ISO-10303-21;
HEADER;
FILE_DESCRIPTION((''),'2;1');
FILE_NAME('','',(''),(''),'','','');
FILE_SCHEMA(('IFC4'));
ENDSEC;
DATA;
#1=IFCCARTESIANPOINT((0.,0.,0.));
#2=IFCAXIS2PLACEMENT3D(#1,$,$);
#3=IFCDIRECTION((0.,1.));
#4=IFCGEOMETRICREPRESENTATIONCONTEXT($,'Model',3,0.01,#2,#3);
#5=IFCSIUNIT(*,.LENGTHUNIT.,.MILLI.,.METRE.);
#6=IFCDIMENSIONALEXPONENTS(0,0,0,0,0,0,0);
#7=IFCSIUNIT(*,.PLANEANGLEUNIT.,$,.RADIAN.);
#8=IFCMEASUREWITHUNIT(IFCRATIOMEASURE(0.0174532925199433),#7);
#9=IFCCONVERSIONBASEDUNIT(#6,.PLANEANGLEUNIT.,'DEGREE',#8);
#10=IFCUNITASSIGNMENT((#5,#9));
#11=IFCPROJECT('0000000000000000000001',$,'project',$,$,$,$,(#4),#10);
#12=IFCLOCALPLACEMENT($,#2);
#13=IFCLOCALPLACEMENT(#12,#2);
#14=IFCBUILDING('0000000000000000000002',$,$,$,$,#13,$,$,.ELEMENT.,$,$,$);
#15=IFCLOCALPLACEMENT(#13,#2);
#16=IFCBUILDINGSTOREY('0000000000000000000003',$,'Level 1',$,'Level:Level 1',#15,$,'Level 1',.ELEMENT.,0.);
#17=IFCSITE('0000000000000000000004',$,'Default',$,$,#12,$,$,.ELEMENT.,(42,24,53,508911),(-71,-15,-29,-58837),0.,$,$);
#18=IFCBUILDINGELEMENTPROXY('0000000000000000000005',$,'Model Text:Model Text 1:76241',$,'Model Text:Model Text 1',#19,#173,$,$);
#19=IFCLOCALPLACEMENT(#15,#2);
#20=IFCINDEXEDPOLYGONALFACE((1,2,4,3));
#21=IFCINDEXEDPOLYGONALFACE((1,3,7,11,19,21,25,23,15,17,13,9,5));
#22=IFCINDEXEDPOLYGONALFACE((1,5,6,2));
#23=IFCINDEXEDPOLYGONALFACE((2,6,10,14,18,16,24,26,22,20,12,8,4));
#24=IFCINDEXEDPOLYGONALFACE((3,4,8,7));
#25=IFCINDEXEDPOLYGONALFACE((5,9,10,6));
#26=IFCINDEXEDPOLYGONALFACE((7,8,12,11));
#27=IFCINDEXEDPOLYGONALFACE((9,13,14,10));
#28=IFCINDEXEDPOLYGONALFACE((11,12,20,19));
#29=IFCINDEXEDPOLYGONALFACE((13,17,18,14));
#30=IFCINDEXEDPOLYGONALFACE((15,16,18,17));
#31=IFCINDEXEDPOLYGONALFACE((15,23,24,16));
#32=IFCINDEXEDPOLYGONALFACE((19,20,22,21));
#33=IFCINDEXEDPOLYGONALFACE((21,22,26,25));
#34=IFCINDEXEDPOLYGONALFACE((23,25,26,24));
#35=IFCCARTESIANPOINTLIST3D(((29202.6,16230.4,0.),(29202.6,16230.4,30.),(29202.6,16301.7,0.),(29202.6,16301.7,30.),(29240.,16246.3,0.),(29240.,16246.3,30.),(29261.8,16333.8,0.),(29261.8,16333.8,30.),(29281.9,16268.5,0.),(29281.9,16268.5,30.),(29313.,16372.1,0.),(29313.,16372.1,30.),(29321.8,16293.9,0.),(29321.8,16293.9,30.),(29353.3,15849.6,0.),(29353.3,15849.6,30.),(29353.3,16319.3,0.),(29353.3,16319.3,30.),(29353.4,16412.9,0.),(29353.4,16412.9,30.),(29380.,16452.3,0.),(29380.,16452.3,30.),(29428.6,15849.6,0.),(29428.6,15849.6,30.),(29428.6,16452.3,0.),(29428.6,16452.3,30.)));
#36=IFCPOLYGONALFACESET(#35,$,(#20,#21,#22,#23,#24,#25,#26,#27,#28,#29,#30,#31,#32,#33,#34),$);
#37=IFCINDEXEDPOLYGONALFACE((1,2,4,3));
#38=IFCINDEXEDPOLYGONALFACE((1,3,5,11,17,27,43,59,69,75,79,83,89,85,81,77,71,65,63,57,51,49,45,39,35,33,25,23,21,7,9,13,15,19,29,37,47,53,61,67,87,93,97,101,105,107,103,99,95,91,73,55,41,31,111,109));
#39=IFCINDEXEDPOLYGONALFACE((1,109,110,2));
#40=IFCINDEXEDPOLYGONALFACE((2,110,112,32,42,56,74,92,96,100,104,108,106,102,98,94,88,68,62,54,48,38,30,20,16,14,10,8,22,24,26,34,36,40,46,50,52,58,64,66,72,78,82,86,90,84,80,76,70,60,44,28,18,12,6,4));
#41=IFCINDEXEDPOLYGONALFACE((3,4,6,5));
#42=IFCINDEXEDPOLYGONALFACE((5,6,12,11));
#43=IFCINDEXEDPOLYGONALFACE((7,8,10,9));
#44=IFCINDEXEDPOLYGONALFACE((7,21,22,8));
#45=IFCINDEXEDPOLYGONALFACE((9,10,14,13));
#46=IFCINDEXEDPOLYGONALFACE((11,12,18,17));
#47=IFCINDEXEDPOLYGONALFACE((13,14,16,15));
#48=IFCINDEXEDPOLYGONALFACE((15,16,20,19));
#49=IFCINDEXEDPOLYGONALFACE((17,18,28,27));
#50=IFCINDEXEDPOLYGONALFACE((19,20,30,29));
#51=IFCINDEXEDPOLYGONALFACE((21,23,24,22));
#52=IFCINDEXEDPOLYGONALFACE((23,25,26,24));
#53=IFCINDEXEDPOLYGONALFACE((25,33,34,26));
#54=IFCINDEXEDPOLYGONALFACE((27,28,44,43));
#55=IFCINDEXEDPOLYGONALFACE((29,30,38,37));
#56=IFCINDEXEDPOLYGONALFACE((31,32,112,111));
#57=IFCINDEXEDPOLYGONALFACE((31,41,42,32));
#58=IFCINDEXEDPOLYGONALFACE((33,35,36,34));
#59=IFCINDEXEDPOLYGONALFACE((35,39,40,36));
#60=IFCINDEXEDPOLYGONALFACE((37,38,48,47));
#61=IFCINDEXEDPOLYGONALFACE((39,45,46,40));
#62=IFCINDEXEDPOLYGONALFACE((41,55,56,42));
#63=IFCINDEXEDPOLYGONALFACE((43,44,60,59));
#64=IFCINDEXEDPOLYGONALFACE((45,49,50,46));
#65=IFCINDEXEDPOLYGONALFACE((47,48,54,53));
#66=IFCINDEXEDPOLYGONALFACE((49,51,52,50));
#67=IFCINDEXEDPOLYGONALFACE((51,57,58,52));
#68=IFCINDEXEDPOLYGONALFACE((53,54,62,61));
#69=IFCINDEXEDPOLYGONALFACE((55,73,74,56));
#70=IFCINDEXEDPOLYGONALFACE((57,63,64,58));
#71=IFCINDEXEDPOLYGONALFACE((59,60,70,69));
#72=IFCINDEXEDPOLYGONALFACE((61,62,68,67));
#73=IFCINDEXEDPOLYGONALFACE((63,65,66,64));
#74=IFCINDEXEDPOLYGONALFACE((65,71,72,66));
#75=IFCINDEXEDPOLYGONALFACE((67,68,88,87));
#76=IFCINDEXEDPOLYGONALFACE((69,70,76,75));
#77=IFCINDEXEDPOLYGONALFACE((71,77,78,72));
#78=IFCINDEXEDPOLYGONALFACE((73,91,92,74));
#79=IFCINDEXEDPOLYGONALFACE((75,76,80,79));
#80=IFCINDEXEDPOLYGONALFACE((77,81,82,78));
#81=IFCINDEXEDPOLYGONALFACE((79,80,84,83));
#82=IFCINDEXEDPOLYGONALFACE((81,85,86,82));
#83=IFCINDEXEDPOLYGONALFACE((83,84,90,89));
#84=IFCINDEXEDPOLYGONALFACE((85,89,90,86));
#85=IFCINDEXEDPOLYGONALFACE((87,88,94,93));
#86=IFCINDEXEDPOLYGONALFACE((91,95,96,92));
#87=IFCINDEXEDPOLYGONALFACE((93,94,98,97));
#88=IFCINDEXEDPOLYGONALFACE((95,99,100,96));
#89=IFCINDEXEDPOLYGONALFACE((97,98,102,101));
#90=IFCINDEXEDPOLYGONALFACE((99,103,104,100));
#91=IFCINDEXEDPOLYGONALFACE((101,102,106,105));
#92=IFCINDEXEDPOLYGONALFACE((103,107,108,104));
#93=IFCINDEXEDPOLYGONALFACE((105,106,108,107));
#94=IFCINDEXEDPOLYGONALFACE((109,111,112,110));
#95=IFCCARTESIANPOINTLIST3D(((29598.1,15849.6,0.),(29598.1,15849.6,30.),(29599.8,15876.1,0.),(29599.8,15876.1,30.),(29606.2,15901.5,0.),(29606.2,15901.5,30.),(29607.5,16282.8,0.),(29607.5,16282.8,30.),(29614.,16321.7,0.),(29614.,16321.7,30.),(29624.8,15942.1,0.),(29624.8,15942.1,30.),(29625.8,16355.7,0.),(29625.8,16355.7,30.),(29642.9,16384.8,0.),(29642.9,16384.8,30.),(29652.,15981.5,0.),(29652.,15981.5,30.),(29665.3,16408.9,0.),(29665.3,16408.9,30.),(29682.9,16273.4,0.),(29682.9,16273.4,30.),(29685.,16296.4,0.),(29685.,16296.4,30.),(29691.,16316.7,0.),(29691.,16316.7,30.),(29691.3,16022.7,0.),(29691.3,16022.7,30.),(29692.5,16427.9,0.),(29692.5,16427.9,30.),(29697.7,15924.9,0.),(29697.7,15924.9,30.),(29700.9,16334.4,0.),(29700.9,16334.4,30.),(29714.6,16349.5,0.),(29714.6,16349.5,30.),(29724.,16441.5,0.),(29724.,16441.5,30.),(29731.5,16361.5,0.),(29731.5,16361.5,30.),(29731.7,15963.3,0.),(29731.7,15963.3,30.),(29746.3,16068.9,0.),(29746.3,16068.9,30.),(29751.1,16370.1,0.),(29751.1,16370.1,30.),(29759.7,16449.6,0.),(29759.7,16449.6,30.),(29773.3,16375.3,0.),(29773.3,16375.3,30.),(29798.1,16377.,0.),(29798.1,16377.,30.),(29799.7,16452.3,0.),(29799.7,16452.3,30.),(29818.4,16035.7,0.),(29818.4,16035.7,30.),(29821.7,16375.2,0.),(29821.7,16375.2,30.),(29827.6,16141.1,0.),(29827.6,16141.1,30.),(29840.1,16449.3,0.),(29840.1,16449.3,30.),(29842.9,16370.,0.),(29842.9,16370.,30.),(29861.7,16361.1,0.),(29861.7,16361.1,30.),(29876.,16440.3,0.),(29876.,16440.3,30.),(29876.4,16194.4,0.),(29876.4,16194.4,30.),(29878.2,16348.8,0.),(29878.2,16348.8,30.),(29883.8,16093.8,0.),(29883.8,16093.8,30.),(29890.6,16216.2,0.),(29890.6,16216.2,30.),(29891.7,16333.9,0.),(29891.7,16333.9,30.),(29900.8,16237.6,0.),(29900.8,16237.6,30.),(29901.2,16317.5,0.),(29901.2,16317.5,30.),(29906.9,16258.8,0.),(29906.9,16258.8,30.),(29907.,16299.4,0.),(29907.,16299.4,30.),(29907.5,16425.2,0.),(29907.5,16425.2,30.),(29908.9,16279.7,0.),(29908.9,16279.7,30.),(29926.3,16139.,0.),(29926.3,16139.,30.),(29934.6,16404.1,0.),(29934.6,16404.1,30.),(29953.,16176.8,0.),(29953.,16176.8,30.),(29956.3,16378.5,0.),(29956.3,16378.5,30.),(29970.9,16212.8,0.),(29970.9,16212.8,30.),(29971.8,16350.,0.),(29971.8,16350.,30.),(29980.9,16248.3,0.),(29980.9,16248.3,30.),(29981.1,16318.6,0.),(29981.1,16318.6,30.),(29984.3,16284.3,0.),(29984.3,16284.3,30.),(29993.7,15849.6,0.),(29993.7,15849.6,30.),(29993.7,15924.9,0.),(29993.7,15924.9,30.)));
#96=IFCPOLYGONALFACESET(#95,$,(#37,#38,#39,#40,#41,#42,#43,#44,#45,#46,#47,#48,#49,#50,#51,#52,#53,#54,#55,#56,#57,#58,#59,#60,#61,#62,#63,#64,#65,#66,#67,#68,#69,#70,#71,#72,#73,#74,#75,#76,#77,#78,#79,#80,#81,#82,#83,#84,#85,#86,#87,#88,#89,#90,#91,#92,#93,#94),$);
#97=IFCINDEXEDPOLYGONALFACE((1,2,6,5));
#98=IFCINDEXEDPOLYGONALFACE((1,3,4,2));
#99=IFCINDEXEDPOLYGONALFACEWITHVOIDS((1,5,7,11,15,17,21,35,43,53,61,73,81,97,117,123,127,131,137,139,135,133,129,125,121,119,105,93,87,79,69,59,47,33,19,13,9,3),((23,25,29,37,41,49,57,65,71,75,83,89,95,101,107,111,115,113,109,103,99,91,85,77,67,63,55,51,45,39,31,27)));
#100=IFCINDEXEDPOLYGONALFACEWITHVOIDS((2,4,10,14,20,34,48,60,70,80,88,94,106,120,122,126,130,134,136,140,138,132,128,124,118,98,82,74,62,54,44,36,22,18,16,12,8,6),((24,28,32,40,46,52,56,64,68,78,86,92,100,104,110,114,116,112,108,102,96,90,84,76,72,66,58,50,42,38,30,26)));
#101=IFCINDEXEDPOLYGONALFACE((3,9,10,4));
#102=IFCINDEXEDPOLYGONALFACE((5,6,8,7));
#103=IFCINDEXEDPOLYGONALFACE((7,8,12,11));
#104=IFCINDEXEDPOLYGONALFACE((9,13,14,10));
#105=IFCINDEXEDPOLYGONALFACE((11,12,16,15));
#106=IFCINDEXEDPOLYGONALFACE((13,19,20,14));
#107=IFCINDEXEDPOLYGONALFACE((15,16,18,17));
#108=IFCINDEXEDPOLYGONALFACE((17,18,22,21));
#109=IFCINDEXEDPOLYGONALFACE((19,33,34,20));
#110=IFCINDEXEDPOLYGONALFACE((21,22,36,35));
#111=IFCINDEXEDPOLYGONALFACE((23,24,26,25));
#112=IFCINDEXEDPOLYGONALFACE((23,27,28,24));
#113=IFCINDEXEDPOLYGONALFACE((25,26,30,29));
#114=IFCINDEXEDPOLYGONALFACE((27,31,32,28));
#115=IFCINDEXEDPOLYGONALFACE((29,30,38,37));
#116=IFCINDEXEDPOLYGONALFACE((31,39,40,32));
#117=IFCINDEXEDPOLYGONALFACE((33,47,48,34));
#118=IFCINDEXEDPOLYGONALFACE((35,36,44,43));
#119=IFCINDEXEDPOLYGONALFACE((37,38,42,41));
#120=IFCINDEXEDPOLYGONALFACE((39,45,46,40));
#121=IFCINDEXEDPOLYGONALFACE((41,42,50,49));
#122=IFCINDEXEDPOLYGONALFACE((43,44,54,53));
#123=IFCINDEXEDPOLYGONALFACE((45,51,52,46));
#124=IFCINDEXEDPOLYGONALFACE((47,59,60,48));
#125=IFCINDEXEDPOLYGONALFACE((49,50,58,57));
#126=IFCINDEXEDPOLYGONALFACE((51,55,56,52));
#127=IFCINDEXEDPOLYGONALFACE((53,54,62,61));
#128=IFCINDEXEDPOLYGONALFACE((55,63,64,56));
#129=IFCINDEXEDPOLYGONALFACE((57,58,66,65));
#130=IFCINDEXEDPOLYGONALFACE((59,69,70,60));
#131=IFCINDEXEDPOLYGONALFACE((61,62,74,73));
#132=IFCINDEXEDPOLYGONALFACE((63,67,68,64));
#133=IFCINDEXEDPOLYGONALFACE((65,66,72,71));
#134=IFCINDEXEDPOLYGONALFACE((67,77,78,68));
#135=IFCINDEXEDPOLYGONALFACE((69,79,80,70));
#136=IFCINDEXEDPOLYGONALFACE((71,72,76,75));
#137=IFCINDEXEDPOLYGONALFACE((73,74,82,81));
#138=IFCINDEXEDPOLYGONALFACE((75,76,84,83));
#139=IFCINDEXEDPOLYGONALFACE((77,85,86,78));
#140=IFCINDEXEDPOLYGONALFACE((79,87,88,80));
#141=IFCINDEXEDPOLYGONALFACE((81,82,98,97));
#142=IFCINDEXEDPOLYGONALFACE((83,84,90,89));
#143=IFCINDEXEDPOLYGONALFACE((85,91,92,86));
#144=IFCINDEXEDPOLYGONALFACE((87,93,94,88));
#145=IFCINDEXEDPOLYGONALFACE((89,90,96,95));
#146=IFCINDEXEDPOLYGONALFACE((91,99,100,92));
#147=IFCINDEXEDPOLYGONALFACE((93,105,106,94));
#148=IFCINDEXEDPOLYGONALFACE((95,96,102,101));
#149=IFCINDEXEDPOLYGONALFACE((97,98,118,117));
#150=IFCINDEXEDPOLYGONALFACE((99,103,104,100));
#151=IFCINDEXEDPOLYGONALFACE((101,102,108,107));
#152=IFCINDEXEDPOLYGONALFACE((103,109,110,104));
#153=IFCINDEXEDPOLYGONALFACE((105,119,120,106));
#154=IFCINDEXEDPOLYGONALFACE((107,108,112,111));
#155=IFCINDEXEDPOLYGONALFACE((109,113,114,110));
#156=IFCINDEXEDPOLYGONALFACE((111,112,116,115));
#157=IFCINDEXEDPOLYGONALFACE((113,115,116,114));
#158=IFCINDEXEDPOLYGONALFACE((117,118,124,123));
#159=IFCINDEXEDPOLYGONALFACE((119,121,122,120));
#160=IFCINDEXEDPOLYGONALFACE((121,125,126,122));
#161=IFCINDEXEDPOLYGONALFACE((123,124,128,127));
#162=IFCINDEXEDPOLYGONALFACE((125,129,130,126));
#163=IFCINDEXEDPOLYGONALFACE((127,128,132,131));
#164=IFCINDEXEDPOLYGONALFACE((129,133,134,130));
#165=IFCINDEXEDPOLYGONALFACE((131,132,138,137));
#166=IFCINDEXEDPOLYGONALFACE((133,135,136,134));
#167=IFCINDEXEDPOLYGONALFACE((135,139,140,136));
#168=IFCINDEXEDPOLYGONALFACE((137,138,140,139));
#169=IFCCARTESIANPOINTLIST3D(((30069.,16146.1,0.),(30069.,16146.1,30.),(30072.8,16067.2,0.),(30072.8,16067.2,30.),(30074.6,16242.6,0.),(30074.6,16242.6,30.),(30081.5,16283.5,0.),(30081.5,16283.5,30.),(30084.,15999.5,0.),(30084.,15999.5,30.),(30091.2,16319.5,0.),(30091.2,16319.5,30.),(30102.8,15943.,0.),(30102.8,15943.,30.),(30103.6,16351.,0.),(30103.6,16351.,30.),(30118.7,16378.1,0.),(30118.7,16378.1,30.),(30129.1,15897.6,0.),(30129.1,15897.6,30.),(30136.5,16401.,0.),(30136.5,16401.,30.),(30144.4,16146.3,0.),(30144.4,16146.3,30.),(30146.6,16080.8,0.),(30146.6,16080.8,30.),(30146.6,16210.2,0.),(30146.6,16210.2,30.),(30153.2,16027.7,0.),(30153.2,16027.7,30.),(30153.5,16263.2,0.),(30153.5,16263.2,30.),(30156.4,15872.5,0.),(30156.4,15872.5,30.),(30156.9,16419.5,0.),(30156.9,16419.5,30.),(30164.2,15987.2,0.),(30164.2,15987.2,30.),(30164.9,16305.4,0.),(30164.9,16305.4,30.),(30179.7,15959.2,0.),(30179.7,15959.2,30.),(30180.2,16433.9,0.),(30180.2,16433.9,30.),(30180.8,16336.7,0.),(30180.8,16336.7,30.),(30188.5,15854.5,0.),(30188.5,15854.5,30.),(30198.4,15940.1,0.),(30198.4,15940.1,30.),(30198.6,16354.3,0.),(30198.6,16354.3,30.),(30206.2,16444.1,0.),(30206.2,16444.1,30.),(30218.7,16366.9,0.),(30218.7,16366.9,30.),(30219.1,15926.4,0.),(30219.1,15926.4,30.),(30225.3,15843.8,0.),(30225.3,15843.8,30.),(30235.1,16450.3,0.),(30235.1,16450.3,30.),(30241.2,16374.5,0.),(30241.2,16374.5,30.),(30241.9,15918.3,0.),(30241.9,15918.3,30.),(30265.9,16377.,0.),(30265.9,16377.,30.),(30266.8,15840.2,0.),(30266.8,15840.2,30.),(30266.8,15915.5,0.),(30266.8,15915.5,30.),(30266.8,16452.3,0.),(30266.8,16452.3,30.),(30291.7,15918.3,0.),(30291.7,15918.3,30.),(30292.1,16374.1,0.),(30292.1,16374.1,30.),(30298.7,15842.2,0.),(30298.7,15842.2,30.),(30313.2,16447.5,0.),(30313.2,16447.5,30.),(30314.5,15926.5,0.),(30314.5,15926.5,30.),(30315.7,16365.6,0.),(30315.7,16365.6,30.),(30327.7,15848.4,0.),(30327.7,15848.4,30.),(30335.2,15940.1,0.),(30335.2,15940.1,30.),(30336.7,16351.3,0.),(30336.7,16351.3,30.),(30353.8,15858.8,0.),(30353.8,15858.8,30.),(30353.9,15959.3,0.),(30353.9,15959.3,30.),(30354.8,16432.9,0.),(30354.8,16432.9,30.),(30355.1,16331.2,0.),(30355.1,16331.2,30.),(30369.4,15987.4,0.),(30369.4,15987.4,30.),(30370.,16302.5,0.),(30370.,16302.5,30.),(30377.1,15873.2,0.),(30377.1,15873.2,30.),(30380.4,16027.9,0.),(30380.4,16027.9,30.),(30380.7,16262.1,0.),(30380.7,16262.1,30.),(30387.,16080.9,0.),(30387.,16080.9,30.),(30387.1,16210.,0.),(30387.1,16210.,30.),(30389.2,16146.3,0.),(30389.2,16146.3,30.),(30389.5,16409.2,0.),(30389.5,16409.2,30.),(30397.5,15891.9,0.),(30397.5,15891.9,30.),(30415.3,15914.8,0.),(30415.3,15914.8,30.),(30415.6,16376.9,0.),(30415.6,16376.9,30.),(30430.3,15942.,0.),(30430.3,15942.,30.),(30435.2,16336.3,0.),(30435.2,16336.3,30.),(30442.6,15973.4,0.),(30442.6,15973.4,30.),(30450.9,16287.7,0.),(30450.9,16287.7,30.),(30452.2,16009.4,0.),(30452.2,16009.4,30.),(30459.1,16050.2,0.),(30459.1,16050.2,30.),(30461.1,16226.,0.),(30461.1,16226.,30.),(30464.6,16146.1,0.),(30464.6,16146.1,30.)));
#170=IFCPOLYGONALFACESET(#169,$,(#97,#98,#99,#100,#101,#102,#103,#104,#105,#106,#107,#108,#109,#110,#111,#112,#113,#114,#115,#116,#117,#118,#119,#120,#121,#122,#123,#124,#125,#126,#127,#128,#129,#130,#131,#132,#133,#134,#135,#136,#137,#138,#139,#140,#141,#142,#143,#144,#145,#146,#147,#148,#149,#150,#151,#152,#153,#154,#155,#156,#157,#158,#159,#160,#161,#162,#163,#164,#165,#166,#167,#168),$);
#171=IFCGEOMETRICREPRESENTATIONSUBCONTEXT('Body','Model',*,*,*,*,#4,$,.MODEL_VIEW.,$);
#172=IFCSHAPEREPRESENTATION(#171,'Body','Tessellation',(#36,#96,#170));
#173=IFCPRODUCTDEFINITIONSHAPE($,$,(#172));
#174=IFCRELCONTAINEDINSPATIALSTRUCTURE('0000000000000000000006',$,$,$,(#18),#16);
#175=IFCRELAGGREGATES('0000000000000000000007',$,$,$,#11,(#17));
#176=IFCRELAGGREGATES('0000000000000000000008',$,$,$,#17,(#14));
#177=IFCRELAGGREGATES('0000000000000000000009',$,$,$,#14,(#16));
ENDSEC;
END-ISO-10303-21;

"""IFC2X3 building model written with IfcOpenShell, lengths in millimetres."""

from ifc_helpers import new_model, entity, si_unit, converted_unit, direction, frame, origin, place, context, subcontext, project, spatial, polyline, outline, extrude, element, save


model = new_model("IFC2X3")

# Units and contexts
model_context = context("Model", 3, precision=0.01, world=origin(), true_north=direction((0.0, 1.0)))
body_context = subcontext(model_context, "Body", "Model", "MODEL_VIEW")
ifc_project = project(units=[si_unit("LENGTHUNIT", "METRE", prefix="MILLI"), converted_unit("PLANEANGLEUNIT", "DEGREE", entity("IfcRatioMeasure", 0.0174532925199433), si_unit("PLANEANGLEUNIT", "RADIAN"), dimensions=[0, 0, 0, 0, 0, 0, 0])], contexts=[model_context])

# Site, building, storey
site_placement = place(None, origin())
site = spatial("IfcSite", under=ifc_project, at=site_placement, Name="Default", CompositionType="ELEMENT", RefLatitude=(42, 24, 53, 508911), RefLongitude=(-71, -15, -29, -58837), RefElevation=0.0)
building_placement = place(site_placement, origin())
building = spatial("IfcBuilding", under=site, at=building_placement, CompositionType="ELEMENT")
storey_placement = place(building_placement, origin())
storey = spatial("IfcBuildingStorey", under=building, at=storey_placement, Name="Level 1", ObjectType="Level:Level 1", LongName="Level 1", CompositionType="ELEMENT", Elevation=0.0)

# Building element proxy
proxy_1_placement = place(storey_placement, origin())
element("IfcBuildingElementProxy", 1, at=proxy_1_placement, inside=storey, Name="Model Text:Model Text 1:76241", ObjectType="Model Text:Model Text 1", context=body_context, shape_type="SweptSolid", body=[
    extrude(outline(polyline([(-410.6, -111.6), (192.1, -111.6), (192.1, -63.1), (152.7, -36.4), (111.9, 4.0), (73.6, 55.2), (41.4, 114.4), (-29.8, 114.4), (-13.9, 77.0), (8.3, 35.1), (33.7, -4.8), (59.1, -36.3), (-410.6, -36.3), (-410.6, -111.6)])), frame((29317.0, 16260.2, 0.0), z_axis=(0.0, 0.0, 1.0), x_axis=(0.0, 1.0, 0.0)), (0.0, 0.0, 1.0), 30.0),
    extrude(outline(polyline([(-190.2, -317.5), (-190.2, -392.8), (205.4, -392.8), (203.7, -366.3), (197.3, -340.9), (178.7, -300.3), (151.5, -260.9), (112.2, -219.7), (57.2, -173.6), (-24.1, -101.3), (-72.9, -48.0), (-87.1, -26.3), (-97.3, -4.8), (-103.4, 16.4), (-105.4, 37.3), (-103.5, 57.0), (-97.7, 75.0), (-88.2, 91.5), (-74.7, 106.4), (-58.2, 118.7), (-39.4, 127.5), (-18.2, 132.8), (5.4, 134.6), (30.2, 132.9), (52.4, 127.7), (72.0, 119.1), (88.9, 107.1), (102.6, 92.0), (112.5, 74.3), (118.5, 54.0), (120.6, 31.0), (196.0, 40.4), (189.5, 79.3), (177.7, 113.3), (160.6, 142.4), (138.2, 166.5), (111.0, 185.5), (79.5, 199.1), (43.8, 207.2), (3.8, 209.9), (-36.6, 206.9), (-72.5, 197.9), (-104.0, 182.8), (-131.1, 161.7), (-152.8, 136.1), (-168.3, 107.6), (-177.6, 76.2), (-180.8, 41.9), (-177.4, 5.8), (-167.4, -29.6), (-149.5, -65.6), (-122.8, -103.4), (-80.3, -148.6), (-14.9, -206.7), (71.8, -279.1), (105.8, -317.5), (-190.2, -317.5)])), frame((29803.5, 16242.4, 0.0), z_axis=(0.0, 0.0, -1.0), x_axis=(-1.0, 0.0, 0.0)), (0.0, 0.0, -1.0), 30.0),
    extrude(outline(polyline([(-10.6, -198.7), (68.3, -198.7), (136.5, -190.7), (193.9, -174.7), (240.5, -150.6), (266.9, -124.4), (286.3, -93.2), (298.8, -57.0), (304.3, -15.7), (303.8, 16.2), (299.0, 45.5), (289.9, 72.1), (276.6, 96.0), (258.9, 117.3), (236.9, 136.2), (210.4, 152.5), (179.6, 166.3), (144.1, 177.6), (103.7, 186.3), (8.2, 196.4), (-71.8, 196.7), (-134.0, 189.4), (-183.3, 176.1), (-224.7, 158.4), (-258.2, 133.9), (-283.5, 100.3), (-300.1, 59.5), (-307.1, 13.4), (-306.6, -18.4), (-301.8, -47.5), (-292.8, -74.0), (-279.6, -97.9), (-262.0, -119.2), (-240.0, -138.1), (-213.6, -154.5), (-182.8, -168.4), (-147.3, -179.8), (-106.7, -188.6), (-10.6, -198.7)]), holes=[polyline([(-7.2, -123.5), (-71.0, -118.2), (-123.6, -108.8), (-165.2, -95.4), (-195.7, -78.0), (-212.4, -59.4), (-224.1, -38.7), (-230.6, -15.9), (-231.9, 8.9), (-227.8, 35.0), (-218.1, 58.1), (-202.8, 78.4), (-182.0, 95.8), (-152.6, 109.4), (-111.7, 118.1), (-59.4, 122.0), (4.4, 121.1), (69.6, 115.8), (122.2, 106.7), (162.2, 93.7), (189.5, 77.0), (207.7, 57.4), (220.4, 36.0), (227.5, 12.8), (229.1, -12.1), (225.2, -36.8), (215.9, -59.2), (201.3, -79.3), (181.4, -97.1), (152.6, -111.2), (111.6, -120.3), (58.3, -124.4), (-7.2, -123.5)])]), frame((30268.0, 16144.9, 0.0), z_axis=(0.0, 0.0, 1.0), x_axis=(0.047515, -0.998871, 0.0)), (0.0, 0.0, 1.0), 30.0),
])

save(model, "model.ifc")
